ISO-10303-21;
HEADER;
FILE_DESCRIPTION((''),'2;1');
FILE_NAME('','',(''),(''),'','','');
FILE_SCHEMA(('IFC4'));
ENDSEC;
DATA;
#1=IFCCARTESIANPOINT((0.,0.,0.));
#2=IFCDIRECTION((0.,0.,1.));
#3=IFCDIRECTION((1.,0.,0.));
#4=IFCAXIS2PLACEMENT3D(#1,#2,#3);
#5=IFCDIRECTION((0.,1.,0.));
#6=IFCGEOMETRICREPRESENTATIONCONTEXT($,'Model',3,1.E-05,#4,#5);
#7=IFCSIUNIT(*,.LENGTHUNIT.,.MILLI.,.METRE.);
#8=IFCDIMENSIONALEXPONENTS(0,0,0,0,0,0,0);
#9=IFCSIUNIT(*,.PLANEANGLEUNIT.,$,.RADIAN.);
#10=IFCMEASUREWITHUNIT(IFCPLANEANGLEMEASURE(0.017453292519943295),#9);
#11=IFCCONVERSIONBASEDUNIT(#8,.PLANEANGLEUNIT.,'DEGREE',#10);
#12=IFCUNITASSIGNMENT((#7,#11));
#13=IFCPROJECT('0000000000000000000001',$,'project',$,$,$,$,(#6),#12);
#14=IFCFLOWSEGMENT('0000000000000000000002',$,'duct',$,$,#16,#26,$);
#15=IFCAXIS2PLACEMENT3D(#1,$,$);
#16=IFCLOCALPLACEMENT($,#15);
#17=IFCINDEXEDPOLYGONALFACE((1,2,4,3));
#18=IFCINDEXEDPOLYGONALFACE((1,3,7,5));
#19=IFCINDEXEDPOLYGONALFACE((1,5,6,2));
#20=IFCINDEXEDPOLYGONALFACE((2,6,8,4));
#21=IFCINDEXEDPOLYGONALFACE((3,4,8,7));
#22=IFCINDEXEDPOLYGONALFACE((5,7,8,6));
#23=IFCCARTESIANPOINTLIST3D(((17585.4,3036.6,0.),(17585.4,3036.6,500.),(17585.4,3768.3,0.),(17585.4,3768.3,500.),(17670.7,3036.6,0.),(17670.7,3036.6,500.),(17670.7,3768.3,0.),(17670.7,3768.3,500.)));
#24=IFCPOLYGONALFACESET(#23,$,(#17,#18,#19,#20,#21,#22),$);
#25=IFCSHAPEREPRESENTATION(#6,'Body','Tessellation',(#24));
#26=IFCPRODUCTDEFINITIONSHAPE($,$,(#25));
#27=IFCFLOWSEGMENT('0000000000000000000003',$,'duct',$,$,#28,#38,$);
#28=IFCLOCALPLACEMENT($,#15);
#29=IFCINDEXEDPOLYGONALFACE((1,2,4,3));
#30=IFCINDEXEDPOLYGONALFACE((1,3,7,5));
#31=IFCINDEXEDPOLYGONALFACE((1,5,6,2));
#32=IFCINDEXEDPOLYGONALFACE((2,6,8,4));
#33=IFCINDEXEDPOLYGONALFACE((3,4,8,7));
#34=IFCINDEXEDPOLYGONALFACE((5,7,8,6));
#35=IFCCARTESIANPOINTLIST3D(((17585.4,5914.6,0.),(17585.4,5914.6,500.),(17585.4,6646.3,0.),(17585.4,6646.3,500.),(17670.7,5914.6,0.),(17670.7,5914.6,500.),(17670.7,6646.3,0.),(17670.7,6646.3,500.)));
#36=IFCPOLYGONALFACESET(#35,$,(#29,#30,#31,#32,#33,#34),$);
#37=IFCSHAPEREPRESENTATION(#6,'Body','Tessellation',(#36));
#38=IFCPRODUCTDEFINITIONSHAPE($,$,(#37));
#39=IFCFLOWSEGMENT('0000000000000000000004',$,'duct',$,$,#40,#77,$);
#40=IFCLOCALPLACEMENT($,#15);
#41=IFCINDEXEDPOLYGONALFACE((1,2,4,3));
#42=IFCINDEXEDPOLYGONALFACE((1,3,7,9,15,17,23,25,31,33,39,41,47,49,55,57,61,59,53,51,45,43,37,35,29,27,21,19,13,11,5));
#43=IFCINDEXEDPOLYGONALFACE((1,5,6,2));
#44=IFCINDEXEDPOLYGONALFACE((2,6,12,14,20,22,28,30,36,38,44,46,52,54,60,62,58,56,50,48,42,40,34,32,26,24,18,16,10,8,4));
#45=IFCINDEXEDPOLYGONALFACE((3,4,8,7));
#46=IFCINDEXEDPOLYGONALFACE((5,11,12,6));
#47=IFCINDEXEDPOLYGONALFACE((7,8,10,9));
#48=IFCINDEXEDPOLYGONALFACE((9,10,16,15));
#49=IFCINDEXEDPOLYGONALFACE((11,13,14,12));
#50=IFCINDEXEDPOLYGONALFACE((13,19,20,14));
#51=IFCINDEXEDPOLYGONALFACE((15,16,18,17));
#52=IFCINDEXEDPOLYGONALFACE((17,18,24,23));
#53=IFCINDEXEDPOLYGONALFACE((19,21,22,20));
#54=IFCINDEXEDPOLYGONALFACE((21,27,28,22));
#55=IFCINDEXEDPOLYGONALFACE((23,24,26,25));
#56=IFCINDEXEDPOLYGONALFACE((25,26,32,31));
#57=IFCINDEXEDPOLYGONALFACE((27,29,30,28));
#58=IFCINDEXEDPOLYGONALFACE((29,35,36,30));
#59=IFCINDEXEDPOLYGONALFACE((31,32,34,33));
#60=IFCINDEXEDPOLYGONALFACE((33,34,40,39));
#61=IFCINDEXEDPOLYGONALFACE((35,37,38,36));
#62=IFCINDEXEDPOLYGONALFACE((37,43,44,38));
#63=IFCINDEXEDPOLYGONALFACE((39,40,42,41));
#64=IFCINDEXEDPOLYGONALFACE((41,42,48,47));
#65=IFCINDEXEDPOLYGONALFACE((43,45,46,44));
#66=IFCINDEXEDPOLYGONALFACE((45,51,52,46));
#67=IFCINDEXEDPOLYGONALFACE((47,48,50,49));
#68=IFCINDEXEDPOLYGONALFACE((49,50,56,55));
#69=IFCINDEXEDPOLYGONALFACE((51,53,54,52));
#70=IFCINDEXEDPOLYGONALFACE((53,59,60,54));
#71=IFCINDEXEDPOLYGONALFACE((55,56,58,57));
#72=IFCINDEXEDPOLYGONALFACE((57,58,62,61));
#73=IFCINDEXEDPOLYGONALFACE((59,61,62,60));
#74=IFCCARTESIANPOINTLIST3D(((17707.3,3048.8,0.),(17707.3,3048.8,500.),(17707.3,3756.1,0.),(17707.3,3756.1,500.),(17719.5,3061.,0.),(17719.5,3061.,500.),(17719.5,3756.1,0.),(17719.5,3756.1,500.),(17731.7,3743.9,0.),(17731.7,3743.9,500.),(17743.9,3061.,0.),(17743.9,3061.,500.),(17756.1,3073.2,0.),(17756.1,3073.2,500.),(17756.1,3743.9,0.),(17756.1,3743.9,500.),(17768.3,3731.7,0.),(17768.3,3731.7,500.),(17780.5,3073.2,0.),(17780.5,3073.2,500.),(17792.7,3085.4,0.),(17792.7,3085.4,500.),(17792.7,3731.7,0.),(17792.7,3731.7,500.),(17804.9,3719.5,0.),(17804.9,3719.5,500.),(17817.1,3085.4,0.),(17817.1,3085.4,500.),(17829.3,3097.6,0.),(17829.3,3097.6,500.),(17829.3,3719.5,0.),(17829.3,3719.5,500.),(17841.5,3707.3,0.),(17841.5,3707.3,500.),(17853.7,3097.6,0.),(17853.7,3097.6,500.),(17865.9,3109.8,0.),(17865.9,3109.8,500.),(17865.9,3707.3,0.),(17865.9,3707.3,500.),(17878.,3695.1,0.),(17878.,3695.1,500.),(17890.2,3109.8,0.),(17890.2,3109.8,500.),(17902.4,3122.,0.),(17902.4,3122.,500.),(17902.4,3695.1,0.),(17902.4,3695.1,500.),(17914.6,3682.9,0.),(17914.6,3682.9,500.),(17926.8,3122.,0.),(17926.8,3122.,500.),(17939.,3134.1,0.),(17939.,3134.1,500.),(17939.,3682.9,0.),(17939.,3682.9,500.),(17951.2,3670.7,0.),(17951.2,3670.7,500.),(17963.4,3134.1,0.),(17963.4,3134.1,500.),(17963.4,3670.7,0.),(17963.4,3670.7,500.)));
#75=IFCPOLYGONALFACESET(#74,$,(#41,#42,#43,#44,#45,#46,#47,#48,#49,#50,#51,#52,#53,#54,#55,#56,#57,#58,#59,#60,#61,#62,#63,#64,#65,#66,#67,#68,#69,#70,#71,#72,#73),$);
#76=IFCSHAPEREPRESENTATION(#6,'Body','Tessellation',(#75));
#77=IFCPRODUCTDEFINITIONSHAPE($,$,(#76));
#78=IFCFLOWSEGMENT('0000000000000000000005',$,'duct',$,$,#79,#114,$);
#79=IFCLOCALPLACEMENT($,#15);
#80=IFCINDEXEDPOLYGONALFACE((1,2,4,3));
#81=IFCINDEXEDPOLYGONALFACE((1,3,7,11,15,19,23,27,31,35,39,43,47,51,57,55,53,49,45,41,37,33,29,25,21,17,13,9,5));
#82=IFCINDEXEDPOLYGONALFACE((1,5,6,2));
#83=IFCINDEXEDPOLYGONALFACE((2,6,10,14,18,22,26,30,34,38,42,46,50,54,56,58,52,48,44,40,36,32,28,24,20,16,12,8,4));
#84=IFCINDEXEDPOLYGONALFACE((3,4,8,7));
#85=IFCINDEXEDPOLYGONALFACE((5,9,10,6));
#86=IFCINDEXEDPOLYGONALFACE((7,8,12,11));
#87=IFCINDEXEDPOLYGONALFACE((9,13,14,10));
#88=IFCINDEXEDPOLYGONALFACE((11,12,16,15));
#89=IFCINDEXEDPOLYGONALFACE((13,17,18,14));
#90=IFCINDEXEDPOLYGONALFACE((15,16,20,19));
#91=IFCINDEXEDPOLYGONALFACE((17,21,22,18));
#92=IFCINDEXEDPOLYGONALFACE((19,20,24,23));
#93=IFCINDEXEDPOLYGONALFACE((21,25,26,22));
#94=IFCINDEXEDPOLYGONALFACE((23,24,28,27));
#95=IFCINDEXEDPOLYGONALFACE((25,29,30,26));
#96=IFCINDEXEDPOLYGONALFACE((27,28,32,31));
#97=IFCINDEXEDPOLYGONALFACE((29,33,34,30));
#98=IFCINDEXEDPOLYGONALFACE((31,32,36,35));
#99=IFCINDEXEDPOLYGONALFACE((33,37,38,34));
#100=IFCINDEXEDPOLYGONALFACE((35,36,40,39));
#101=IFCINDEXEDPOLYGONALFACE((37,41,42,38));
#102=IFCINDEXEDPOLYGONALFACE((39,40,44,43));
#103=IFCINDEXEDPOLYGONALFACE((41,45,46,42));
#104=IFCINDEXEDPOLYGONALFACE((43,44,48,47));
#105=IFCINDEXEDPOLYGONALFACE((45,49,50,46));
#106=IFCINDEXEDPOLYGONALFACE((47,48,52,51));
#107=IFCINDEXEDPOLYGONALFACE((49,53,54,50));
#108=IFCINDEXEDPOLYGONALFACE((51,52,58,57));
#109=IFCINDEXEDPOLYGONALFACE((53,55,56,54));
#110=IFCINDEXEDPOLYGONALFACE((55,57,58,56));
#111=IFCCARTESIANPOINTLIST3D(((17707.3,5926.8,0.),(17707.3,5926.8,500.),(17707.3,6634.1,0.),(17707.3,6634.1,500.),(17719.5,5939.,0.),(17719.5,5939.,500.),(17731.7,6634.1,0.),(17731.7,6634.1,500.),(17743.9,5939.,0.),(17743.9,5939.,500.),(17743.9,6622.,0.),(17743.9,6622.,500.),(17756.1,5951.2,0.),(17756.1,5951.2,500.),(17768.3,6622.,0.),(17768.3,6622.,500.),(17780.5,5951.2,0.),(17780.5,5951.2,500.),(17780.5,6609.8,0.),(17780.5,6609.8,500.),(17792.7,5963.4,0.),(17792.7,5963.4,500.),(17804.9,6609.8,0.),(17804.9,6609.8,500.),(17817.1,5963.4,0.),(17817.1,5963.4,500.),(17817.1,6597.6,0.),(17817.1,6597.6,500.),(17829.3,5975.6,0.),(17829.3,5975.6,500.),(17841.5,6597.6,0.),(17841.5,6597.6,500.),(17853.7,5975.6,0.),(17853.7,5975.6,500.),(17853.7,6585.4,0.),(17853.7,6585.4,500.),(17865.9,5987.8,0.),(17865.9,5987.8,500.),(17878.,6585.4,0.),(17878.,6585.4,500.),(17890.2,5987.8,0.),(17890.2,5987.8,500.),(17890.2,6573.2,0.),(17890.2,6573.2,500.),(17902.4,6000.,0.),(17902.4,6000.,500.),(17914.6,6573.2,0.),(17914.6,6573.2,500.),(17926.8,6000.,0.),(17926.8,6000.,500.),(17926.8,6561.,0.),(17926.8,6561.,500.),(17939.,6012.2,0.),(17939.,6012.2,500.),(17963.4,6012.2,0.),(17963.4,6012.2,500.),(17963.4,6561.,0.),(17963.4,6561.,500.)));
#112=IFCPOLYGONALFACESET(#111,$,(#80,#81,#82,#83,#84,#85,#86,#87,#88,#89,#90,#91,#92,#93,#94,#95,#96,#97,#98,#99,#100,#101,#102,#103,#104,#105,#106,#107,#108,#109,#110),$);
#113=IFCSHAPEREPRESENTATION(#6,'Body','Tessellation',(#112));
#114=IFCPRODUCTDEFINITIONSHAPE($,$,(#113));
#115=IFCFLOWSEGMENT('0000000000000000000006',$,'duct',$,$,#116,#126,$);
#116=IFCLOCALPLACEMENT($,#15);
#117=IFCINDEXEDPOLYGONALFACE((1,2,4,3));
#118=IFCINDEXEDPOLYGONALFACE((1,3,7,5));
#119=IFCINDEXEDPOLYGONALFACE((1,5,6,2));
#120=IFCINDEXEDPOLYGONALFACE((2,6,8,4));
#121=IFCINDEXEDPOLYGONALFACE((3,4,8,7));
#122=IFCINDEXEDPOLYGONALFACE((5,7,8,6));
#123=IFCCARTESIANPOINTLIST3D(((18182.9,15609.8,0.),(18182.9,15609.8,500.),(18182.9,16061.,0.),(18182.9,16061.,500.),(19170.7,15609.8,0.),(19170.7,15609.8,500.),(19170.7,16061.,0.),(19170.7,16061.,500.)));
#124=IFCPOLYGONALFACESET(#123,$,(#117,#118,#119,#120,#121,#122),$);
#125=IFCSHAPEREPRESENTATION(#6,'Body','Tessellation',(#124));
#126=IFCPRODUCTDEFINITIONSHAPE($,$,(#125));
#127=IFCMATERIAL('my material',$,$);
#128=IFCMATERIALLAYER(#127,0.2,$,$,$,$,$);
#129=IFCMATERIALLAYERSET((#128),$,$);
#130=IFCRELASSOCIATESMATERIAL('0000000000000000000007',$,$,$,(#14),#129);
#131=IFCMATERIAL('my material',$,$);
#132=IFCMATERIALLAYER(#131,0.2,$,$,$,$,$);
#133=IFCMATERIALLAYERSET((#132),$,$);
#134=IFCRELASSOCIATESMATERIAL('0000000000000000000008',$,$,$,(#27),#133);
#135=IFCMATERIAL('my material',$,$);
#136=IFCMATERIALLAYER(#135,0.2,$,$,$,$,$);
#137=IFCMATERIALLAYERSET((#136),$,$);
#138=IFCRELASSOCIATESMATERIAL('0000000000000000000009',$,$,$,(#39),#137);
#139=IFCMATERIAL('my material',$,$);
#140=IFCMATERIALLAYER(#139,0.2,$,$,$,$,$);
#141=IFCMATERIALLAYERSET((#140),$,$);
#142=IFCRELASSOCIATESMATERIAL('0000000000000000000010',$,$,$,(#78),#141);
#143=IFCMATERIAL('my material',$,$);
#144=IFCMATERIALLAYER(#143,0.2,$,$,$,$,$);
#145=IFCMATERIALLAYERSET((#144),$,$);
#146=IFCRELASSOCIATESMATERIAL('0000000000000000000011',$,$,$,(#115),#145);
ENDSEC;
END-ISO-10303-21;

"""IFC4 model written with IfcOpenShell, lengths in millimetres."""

from ifc_helpers import new_model, entity, si_unit, converted_unit, direction, origin_with_axes, place, context, project, polyline, outline, extrude, material, layer, layer_set, layer_usage, element, save


model = new_model("IFC4")

# Units and contexts
model_context = context("Model", 3, precision=1e-05, world=origin_with_axes(), true_north=direction((0.0, 1.0, 0.0)))
ifc_project = project(units=[si_unit("LENGTHUNIT", "METRE", prefix="MILLI"), converted_unit("PLANEANGLEUNIT", "DEGREE", entity("IfcPlaneAngleMeasure", 0.017453292519943295), si_unit("PLANEANGLEUNIT", "RADIAN"), dimensions=[0, 0, 0, 0, 0, 0, 0])], contexts=[model_context])

# Flow segments
ifc_material_1 = material(Name="my material")
ifc_layer_1 = layer(ifc_material_1, 0.2)
ifc_layer_set_1 = layer_set([ifc_layer_1])
ifc_layer_usage_1 = layer_usage(ifc_layer_set_1, "AXIS2", "POSITIVE", -0.1)
flow_segment_1_placement = place(None, origin_with_axes())
element("IfcFlowSegment", 1, at=flow_segment_1_placement, material=ifc_layer_usage_1, Name="duct", context=model_context, shape_type="SweptSolid", body=[
    extrude(outline(polyline([(17585.4, 3036.6), (17670.7, 3036.6), (17670.7, 3768.3), (17585.4, 3768.3), (17585.4, 3036.6)])), origin_with_axes(), (0.0, 0.0, 1.0), 500.0),
])
ifc_material_2 = material(Name="my material")
ifc_layer_2 = layer(ifc_material_2, 0.2)
ifc_layer_set_2 = layer_set([ifc_layer_2])
ifc_layer_usage_2 = layer_usage(ifc_layer_set_2, "AXIS2", "POSITIVE", -0.1)
flow_segment_2_placement = place(None, origin_with_axes())
element("IfcFlowSegment", 2, at=flow_segment_2_placement, material=ifc_layer_usage_2, Name="duct", context=model_context, shape_type="SweptSolid", body=[
    extrude(outline(polyline([(17585.4, 5914.6), (17670.7, 5914.6), (17670.7, 6646.3), (17585.4, 6646.3), (17585.4, 5914.6)])), origin_with_axes(), (0.0, 0.0, 1.0), 500.0),
])
ifc_material_3 = material(Name="my material")
ifc_layer_3 = layer(ifc_material_3, 0.2)
ifc_layer_set_3 = layer_set([ifc_layer_3])
ifc_layer_usage_3 = layer_usage(ifc_layer_set_3, "AXIS2", "POSITIVE", -0.1)
flow_segment_3_placement = place(None, origin_with_axes())
element("IfcFlowSegment", 3, at=flow_segment_3_placement, material=ifc_layer_usage_3, Name="duct", context=model_context, shape_type="SweptSolid", body=[
    extrude(outline(polyline([(17707.3, 3048.8), (17719.5, 3061.0), (17743.9, 3061.0), (17756.1, 3073.2), (17780.5, 3073.2), (17792.7, 3085.4), (17817.1, 3085.4), (17829.3, 3097.6), (17853.7, 3097.6), (17865.9, 3109.8), (17890.2, 3109.8), (17902.4, 3122.0), (17926.8, 3122.0), (17939.0, 3134.1), (17963.4, 3134.1), (17963.4, 3670.7), (17951.2, 3670.7), (17939.0, 3682.9), (17914.6, 3682.9), (17902.4, 3695.1), (17878.0, 3695.1), (17865.9, 3707.3), (17841.5, 3707.3), (17829.3, 3719.5), (17804.9, 3719.5), (17792.7, 3731.7), (17768.3, 3731.7), (17756.1, 3743.9), (17731.7, 3743.9), (17719.5, 3756.1), (17707.3, 3756.1), (17707.3, 3048.8)])), origin_with_axes(), (0.0, 0.0, 1.0), 500.0),
])
ifc_material_4 = material(Name="my material")
ifc_layer_4 = layer(ifc_material_4, 0.2)
ifc_layer_set_4 = layer_set([ifc_layer_4])
ifc_layer_usage_4 = layer_usage(ifc_layer_set_4, "AXIS2", "POSITIVE", -0.1)
flow_segment_4_placement = place(None, origin_with_axes())
element("IfcFlowSegment", 4, at=flow_segment_4_placement, material=ifc_layer_usage_4, Name="duct", context=model_context, shape_type="SweptSolid", body=[
    extrude(outline(polyline([(17707.3, 5926.8), (17719.5, 5939.0), (17743.9, 5939.0), (17756.1, 5951.2), (17780.5, 5951.2), (17792.7, 5963.4), (17817.1, 5963.4), (17829.3, 5975.6), (17853.7, 5975.6), (17865.9, 5987.8), (17890.2, 5987.8), (17902.4, 6000.0), (17926.8, 6000.0), (17939.0, 6012.2), (17963.4, 6012.2), (17963.4, 6561.0), (17926.8, 6561.0), (17914.6, 6573.2), (17890.2, 6573.2), (17878.0, 6585.4), (17853.7, 6585.4), (17841.5, 6597.6), (17817.1, 6597.6), (17804.9, 6609.8), (17780.5, 6609.8), (17768.3, 6622.0), (17743.9, 6622.0), (17731.7, 6634.1), (17707.3, 6634.1), (17707.3, 5926.8)])), origin_with_axes(), (0.0, 0.0, 1.0), 500.0),
])
ifc_material_5 = material(Name="my material")
ifc_layer_5 = layer(ifc_material_5, 0.2)
ifc_layer_set_5 = layer_set([ifc_layer_5])
ifc_layer_usage_5 = layer_usage(ifc_layer_set_5, "AXIS2", "POSITIVE", -0.1)
flow_segment_5_placement = place(None, origin_with_axes())
element("IfcFlowSegment", 5, at=flow_segment_5_placement, material=ifc_layer_usage_5, Name="duct", context=model_context, shape_type="SweptSolid", body=[
    extrude(outline(polyline([(18182.9, 15609.8), (19170.7, 15609.8), (19170.7, 16061.0), (18182.9, 16061.0), (18182.9, 15609.8)])), origin_with_axes(), (0.0, 0.0, 1.0), 500.0),
])

save(model, "model.ifc")
